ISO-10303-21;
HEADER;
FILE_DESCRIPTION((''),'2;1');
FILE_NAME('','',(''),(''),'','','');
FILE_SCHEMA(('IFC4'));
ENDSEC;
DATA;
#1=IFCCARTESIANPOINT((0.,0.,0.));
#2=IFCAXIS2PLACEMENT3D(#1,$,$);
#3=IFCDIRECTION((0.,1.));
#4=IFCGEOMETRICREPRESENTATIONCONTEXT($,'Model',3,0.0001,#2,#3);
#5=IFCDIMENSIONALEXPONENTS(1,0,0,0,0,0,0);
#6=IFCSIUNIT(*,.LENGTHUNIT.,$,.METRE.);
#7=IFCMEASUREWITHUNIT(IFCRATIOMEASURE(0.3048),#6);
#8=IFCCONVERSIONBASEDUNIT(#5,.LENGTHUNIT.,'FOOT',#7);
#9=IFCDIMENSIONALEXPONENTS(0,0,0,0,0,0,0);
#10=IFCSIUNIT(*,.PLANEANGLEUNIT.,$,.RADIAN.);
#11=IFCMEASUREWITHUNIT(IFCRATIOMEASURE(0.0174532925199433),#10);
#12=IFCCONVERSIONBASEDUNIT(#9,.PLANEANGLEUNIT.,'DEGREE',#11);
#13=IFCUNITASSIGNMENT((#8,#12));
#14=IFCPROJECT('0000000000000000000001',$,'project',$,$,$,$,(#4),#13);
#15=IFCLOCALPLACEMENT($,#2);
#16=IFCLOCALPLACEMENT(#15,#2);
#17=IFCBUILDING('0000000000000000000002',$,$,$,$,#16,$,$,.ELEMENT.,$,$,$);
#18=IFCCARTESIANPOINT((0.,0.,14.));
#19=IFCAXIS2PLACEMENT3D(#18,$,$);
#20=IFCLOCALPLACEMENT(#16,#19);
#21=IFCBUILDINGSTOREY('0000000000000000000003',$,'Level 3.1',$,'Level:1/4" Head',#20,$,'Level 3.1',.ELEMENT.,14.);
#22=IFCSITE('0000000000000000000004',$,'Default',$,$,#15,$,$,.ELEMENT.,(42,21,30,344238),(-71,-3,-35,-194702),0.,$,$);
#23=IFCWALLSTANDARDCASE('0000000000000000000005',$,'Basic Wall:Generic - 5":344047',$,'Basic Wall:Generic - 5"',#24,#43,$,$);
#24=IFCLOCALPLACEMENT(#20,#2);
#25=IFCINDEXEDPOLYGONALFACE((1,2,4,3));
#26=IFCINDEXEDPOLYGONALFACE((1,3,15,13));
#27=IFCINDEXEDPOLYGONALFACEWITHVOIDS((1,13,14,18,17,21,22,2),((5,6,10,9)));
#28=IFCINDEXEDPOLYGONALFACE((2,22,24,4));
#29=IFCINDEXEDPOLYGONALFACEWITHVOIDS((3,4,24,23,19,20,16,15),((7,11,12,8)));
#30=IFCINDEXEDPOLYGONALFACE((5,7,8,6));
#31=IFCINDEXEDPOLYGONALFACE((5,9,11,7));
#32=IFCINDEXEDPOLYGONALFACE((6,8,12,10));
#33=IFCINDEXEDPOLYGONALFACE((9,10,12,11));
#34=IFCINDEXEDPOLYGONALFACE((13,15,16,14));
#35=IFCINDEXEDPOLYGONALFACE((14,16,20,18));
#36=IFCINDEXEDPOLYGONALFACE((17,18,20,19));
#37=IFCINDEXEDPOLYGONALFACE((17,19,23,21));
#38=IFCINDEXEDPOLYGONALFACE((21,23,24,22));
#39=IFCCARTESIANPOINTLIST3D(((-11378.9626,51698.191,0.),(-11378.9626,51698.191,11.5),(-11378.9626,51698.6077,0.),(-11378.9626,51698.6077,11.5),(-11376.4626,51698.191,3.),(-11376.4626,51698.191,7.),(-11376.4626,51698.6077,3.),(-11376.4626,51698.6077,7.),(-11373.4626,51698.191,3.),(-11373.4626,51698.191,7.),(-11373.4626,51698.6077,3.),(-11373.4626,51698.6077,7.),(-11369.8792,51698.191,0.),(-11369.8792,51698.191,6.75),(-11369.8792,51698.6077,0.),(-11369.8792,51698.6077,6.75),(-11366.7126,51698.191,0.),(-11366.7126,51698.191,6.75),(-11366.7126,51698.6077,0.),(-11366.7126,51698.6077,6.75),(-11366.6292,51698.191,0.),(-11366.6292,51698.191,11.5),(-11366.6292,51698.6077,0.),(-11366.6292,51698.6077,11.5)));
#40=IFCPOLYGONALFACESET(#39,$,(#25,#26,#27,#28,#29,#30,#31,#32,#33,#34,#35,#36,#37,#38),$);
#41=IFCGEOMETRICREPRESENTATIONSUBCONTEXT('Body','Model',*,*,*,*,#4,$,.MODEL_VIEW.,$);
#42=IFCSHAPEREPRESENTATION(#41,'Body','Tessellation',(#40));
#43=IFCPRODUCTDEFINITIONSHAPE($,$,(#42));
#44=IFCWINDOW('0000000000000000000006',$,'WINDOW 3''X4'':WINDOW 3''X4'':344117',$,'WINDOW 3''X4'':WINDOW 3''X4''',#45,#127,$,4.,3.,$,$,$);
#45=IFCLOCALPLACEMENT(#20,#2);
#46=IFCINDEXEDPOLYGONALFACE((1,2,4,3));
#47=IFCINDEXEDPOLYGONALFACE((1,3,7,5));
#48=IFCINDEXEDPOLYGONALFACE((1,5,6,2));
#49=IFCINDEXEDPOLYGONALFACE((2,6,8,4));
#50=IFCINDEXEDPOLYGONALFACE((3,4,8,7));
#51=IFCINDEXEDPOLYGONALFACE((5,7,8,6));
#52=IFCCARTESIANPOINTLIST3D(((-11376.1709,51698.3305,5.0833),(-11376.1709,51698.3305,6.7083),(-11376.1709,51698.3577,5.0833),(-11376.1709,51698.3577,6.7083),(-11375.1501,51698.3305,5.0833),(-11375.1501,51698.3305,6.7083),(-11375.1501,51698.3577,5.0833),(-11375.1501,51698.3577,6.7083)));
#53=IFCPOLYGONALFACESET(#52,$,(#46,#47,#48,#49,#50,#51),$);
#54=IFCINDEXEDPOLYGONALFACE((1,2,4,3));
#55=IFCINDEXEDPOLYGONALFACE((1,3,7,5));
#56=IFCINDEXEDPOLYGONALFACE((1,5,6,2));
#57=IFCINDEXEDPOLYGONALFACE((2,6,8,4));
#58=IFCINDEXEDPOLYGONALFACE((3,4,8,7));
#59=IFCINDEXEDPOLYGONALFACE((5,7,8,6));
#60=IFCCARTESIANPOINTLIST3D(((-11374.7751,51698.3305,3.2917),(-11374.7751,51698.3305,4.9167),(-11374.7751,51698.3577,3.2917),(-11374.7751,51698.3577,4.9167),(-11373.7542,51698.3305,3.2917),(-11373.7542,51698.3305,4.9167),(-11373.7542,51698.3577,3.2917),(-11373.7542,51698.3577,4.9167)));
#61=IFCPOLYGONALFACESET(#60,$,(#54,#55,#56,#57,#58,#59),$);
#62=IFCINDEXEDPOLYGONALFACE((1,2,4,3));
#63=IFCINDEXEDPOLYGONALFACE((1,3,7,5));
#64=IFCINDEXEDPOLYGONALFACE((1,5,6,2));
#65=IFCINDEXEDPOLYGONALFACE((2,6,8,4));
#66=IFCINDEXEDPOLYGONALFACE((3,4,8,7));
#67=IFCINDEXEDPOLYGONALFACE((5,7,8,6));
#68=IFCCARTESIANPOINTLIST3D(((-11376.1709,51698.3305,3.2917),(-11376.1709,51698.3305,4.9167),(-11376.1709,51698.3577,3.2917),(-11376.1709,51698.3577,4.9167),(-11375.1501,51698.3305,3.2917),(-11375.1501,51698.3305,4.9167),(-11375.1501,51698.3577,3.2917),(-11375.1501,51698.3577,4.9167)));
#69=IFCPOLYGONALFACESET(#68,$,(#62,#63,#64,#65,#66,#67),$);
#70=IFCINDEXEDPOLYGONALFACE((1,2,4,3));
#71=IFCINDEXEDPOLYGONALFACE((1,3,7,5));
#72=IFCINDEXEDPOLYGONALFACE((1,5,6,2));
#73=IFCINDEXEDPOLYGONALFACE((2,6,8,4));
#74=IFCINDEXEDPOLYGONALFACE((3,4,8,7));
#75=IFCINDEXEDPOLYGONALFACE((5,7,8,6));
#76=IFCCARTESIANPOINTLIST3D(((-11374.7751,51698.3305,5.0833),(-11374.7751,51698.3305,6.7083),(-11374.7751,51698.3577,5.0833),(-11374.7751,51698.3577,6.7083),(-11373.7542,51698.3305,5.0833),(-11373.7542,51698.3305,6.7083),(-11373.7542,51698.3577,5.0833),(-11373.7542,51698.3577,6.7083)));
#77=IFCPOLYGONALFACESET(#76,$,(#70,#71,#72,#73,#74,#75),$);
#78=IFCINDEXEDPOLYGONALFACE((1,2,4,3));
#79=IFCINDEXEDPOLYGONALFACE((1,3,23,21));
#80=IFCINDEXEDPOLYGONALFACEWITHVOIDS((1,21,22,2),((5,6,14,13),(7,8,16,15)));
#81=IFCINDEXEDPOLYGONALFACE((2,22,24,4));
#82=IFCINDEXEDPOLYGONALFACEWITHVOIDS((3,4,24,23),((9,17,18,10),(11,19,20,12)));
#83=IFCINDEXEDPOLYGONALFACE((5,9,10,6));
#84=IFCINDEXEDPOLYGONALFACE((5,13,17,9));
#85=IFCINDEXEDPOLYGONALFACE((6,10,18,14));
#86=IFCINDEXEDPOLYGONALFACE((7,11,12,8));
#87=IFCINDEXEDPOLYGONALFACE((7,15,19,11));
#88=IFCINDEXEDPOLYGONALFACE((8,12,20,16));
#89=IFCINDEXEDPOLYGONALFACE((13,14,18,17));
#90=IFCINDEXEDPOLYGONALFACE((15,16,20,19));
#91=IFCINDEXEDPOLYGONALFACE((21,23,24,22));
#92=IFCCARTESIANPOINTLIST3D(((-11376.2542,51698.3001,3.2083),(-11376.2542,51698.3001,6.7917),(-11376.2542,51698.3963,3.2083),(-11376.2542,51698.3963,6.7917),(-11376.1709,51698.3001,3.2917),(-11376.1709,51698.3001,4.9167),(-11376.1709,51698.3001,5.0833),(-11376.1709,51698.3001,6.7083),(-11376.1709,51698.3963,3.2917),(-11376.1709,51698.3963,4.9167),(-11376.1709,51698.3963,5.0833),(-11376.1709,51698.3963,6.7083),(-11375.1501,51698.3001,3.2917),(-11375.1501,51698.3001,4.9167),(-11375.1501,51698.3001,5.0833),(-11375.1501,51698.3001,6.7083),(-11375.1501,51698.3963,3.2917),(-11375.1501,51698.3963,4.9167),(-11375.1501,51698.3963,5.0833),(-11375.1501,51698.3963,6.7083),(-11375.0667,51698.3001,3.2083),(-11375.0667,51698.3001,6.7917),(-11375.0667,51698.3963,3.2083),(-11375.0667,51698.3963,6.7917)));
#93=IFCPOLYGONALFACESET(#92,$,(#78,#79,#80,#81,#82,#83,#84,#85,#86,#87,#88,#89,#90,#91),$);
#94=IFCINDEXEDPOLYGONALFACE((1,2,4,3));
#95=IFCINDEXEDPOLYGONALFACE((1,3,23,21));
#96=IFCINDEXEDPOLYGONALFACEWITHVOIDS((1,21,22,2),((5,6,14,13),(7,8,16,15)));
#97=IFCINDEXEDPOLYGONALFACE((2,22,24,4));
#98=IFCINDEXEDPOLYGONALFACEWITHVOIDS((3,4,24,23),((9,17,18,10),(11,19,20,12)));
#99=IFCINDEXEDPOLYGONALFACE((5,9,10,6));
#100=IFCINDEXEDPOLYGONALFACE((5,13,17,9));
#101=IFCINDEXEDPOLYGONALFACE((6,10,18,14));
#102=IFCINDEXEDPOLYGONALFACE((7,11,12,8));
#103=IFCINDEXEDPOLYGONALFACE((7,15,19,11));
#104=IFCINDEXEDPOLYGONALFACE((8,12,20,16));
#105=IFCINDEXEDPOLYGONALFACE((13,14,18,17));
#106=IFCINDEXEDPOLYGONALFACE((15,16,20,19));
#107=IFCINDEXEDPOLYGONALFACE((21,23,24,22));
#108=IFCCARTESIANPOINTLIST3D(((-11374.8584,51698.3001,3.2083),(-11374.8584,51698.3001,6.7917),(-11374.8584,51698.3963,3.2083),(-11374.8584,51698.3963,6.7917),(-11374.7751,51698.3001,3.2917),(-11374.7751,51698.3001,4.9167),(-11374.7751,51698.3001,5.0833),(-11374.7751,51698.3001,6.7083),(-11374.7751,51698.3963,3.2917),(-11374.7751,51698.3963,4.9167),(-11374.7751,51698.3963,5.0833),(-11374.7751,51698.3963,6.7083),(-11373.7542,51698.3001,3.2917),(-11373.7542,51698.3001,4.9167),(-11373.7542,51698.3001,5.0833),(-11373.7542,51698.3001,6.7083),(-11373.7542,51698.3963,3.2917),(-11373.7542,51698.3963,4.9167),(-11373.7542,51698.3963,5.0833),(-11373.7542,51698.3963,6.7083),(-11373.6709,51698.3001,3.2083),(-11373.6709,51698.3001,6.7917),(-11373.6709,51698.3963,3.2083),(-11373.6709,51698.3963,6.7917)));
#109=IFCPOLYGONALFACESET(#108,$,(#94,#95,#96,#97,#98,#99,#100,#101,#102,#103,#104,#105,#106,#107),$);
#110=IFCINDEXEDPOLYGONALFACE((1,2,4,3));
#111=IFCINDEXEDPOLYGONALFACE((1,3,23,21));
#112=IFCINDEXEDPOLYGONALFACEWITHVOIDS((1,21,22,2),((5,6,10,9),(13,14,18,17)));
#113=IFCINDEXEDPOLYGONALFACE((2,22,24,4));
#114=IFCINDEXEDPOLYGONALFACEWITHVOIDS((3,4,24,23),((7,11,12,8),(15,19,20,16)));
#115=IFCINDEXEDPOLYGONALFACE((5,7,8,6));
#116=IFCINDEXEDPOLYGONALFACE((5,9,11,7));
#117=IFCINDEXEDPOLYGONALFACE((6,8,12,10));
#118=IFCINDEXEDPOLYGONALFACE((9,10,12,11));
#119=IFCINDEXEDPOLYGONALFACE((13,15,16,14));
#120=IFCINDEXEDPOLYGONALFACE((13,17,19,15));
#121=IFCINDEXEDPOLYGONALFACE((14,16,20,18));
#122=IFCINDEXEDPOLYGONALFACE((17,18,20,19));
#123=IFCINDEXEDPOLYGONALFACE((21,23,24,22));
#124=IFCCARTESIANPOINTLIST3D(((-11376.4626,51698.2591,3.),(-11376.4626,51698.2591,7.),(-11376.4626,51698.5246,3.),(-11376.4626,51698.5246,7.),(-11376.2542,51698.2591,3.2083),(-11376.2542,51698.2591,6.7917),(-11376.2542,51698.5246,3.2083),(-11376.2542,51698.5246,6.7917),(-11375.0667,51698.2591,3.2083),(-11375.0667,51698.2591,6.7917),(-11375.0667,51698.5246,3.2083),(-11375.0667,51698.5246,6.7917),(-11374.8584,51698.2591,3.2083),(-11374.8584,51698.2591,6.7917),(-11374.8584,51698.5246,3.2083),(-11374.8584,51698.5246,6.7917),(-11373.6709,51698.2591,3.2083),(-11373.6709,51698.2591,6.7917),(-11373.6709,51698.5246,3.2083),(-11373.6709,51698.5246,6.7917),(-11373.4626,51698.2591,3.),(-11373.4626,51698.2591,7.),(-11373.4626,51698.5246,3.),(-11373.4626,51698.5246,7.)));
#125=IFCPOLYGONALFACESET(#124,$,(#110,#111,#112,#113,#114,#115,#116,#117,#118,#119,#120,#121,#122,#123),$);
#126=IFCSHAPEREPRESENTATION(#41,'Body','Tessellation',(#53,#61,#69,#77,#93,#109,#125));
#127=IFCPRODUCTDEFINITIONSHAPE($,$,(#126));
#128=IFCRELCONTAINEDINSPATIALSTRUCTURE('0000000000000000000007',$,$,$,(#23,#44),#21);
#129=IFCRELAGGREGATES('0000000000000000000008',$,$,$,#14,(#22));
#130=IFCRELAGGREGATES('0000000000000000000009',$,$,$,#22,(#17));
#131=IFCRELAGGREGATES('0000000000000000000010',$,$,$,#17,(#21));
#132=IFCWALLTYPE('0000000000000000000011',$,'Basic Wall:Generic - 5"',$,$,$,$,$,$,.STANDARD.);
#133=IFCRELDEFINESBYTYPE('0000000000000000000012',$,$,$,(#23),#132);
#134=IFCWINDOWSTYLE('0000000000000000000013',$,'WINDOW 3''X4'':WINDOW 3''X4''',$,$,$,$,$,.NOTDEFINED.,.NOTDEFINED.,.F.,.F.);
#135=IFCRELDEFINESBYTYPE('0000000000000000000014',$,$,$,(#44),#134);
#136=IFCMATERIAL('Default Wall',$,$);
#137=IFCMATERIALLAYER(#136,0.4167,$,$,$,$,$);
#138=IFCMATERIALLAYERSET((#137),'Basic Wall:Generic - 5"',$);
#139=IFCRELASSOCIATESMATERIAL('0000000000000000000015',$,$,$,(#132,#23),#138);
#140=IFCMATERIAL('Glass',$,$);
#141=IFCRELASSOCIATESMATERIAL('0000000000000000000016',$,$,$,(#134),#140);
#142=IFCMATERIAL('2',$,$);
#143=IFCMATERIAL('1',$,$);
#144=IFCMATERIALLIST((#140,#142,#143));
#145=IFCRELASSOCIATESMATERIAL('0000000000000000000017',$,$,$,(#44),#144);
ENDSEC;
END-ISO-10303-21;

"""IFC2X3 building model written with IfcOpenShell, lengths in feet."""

from ifc_helpers import new_model, entity, si_unit, converted_unit, direction, frame, frame_2d, origin, origin_2d_with_axis, place, context, subcontext, project, spatial, polyline, rectangle, outline, extrude, source, transform, mapped, material, material_list, layer, layer_set, layer_usage, type_object, type_shapes, element, fill, save


model = new_model("IFC2X3")

# Units and contexts
model_context = context("Model", 3, precision=0.0001, world=origin(), true_north=direction((0.0, 1.0)))
body_context = subcontext(model_context, "Body", "Model", "MODEL_VIEW")
ifc_project = project(units=[converted_unit("LENGTHUNIT", "FOOT", entity("IfcRatioMeasure", 0.3048), si_unit("LENGTHUNIT", "METRE"), dimensions=[1, 0, 0, 0, 0, 0, 0]), converted_unit("PLANEANGLEUNIT", "DEGREE", entity("IfcRatioMeasure", 0.0174532925199433), si_unit("PLANEANGLEUNIT", "RADIAN"), dimensions=[0, 0, 0, 0, 0, 0, 0])], contexts=[model_context])

# Site, building, storey
site_placement = place(None, origin())
site = spatial("IfcSite", under=ifc_project, at=site_placement, Name="Default", CompositionType="ELEMENT", RefLatitude=(42, 21, 30, 344238), RefLongitude=(-71, -3, -35, -194702), RefElevation=0.0)
building_placement = place(site_placement, origin())
building = spatial("IfcBuilding", under=site, at=building_placement, CompositionType="ELEMENT")
storey_placement = place(building_placement, frame((0.0, 0.0, 14.0)))
storey = spatial("IfcBuildingStorey", under=building, at=storey_placement, Name="Level 3.1", ObjectType="Level:1/4\" Head", LongName="Level 3.1", CompositionType="ELEMENT", Elevation=14.0)

# Shared definitions
ifc_material_1 = material(Name="Default Wall")
ifc_material_2 = material(Name="Glass")
ifc_material_3 = material(Name="2")
ifc_material_4 = material(Name="1")
ifc_layer_1 = layer(ifc_material_1, 0.4167)
ifc_layer_set_1 = layer_set([ifc_layer_1], Name="Basic Wall:Generic - 5\"")
wall_type_1 = type_object("IfcWallType", Name="Basic Wall:Generic - 5\"", PredefinedType="STANDARD", material=ifc_layer_set_1)

# Wall, openings, window
window_style_1 = type_object("IfcWindowStyle", Name="WINDOW 3'X4':WINDOW 3'X4'", ConstructionType="NOTDEFINED", OperationType="NOTDEFINED", ParameterTakesPrecedence=False, Sizeable=False, material=ifc_material_2)
shared_shape_1 = source(origin(), body_context, "Body", "SweptSolid", [
    extrude(rectangle(XDim=0.0272, YDim=1.0208, at=origin_2d_with_axis()), frame((2.1979, 0.2636, 2.0833), z_axis=(0.0, 0.0, 1.0), x_axis=(0.0, 1.0, 0.0)), (0.0, 0.0, 1.0), 1.625),
    extrude(rectangle(XDim=0.0272, YDim=1.0208, at=origin_2d_with_axis()), frame((0.8021, 0.2636, 0.2917), z_axis=(0.0, 0.0, 1.0), x_axis=(0.0, 1.0, 0.0)), (0.0, 0.0, 1.0), 1.625),
    extrude(rectangle(XDim=0.0272, YDim=1.0208, at=origin_2d_with_axis()), frame((2.1979, 0.2636, 0.2917), z_axis=(0.0, 0.0, 1.0), x_axis=(0.0, 1.0, 0.0)), (0.0, 0.0, 1.0), 1.625),
    extrude(rectangle(XDim=0.0272, YDim=1.0208, at=origin_2d_with_axis()), frame((0.8021, 0.2636, 2.0833), z_axis=(0.0, 0.0, 1.0), x_axis=(0.0, 1.0, 0.0)), (0.0, 0.0, 1.0), 1.625),
    extrude(outline(polyline([(-0.5938, -1.7917), (0.5938, -1.7917), (0.5938, 1.7917), (-0.5938, 1.7917), (-0.5938, -1.7917)]), holes=[polyline([(-0.5104, -0.0833), (0.5104, -0.0833), (0.5104, -1.7083), (-0.5104, -1.7083), (-0.5104, -0.0833)]), polyline([(-0.5104, 1.7083), (0.5104, 1.7083), (0.5104, 0.0833), (-0.5104, 0.0833), (-0.5104, 1.7083)])]), frame((2.1979, 0.2114, 2.0), z_axis=(0.0, 1.0, 0.0), x_axis=(-1.0, 0.0, 0.0)), (0.0, 0.0, 1.0), 0.0962),
    extrude(outline(polyline([(-1.7917, -0.5937), (1.7917, -0.5937), (1.7917, 0.5937), (-1.7917, 0.5937), (-1.7917, -0.5937)]), holes=[polyline([(0.0833, -0.5104), (0.0833, 0.5104), (1.7083, 0.5104), (1.7083, -0.5104), (0.0833, -0.5104)]), polyline([(-1.7083, -0.5104), (-1.7083, 0.5104), (-0.0833, 0.5104), (-0.0833, -0.5104), (-1.7083, -0.5104)])]), frame((0.8021, 0.2114, 2.0), z_axis=(0.0, 1.0, 0.0), x_axis=(0.0, 0.0, -1.0)), (0.0, 0.0, 1.0), 0.0962),
    extrude(outline(polyline([(-1.5, -2.0), (1.5, -2.0), (1.5, 2.0), (-1.5, 2.0), (-1.5, -2.0)]), holes=[polyline([(-0.1042, 1.7917), (-0.1042, -1.7917), (-1.2917, -1.7917), (-1.2917, 1.7917), (-0.1042, 1.7917)]), polyline([(0.1042, -1.7917), (0.1042, 1.7917), (1.2917, 1.7917), (1.2917, -1.7917), (0.1042, -1.7917)])]), frame((1.5, 0.0831, 2.0), z_axis=(0.0, 1.0, 0.0), x_axis=(1.0, 0.0, 0.0)), (0.0, 0.0, 1.0), 0.2655),
])
type_shapes(window_style_1, [shared_shape_1])
ifc_layer_usage_1 = layer_usage(ifc_layer_set_1, "AXIS2", "NEGATIVE", 0.2083)
wall_1_placement = place(storey_placement, frame((-11378.9626, 51698.3993, 0.0)))
wall_1 = element("IfcWallStandardCase", 1, at=wall_1_placement, inside=storey, type_object=wall_type_1, material=ifc_layer_usage_1, Name="Basic Wall:Generic - 5\":344047", ObjectType="Basic Wall:Generic - 5\"", context=body_context, shape_type="SweptSolid", body=[
    extrude(rectangle(XDim=12.3333, YDim=0.4167, at=frame_2d((6.1667, 0.0), x_axis=(-1.0, 0.0))), origin(), (0.0, 0.0, 1.0), 11.5),
])
opening_1_placement = place(wall_1_placement, frame((9.0833, -0.2083, 0.0)))
element("IfcOpeningElement", 2, at=opening_1_placement, cuts=wall_1, ObjectType="Opening", context=body_context, shape_type="SweptSolid", body=[
    extrude(rectangle(XDim=6.75, YDim=3.1667, at=frame_2d((3.375, 1.5833), x_axis=(1.0, 0.0))), frame((0.0, 0.0, 0.0), z_axis=(0.0, 1.0, 0.0), x_axis=(0.0, 0.0, 1.0)), (0.0, 0.0, 1.0), 0.4167),
])
opening_2_placement = place(wall_1_placement, frame((5.5, 0.2083, 3.0)))
opening_2 = element("IfcOpeningElement", 3, at=opening_2_placement, cuts=wall_1, ObjectType="Opening", context=body_context, shape_type="SweptSolid", body=[
    extrude(rectangle(XDim=4.0, YDim=3.0, at=frame_2d((2.0, 1.5), x_axis=(-1.0, 0.0))), frame((0.0, 0.0, 0.0), z_axis=(0.0, -1.0, 0.0), x_axis=(0.0, 0.0, 1.0)), (0.0, 0.0, 1.0), 0.4167),
])
ifc_material_list_1 = material_list([ifc_material_2, ifc_material_3, ifc_material_4])
window_1_placement = place(opening_2_placement, frame((0.0, 0.0, 0.0), z_axis=(0.0, 0.0, 1.0), x_axis=(-1.0, 0.0, 0.0)))
window_1 = element("IfcWindow", 4, at=window_1_placement, inside=storey, type_object=window_style_1, material=ifc_material_list_1, Name="WINDOW 3'X4':WINDOW 3'X4':344117", ObjectType="WINDOW 3'X4':WINDOW 3'X4'", OverallHeight=4.0, OverallWidth=3.0, context=body_context, shape_type="MappedRepresentation", body=[
    mapped(shared_shape_1, transform((0.0, 0.0, 0.0), scale=1.0)),
])
fill(opening_2, window_1)

save(model, "model.ifc")
